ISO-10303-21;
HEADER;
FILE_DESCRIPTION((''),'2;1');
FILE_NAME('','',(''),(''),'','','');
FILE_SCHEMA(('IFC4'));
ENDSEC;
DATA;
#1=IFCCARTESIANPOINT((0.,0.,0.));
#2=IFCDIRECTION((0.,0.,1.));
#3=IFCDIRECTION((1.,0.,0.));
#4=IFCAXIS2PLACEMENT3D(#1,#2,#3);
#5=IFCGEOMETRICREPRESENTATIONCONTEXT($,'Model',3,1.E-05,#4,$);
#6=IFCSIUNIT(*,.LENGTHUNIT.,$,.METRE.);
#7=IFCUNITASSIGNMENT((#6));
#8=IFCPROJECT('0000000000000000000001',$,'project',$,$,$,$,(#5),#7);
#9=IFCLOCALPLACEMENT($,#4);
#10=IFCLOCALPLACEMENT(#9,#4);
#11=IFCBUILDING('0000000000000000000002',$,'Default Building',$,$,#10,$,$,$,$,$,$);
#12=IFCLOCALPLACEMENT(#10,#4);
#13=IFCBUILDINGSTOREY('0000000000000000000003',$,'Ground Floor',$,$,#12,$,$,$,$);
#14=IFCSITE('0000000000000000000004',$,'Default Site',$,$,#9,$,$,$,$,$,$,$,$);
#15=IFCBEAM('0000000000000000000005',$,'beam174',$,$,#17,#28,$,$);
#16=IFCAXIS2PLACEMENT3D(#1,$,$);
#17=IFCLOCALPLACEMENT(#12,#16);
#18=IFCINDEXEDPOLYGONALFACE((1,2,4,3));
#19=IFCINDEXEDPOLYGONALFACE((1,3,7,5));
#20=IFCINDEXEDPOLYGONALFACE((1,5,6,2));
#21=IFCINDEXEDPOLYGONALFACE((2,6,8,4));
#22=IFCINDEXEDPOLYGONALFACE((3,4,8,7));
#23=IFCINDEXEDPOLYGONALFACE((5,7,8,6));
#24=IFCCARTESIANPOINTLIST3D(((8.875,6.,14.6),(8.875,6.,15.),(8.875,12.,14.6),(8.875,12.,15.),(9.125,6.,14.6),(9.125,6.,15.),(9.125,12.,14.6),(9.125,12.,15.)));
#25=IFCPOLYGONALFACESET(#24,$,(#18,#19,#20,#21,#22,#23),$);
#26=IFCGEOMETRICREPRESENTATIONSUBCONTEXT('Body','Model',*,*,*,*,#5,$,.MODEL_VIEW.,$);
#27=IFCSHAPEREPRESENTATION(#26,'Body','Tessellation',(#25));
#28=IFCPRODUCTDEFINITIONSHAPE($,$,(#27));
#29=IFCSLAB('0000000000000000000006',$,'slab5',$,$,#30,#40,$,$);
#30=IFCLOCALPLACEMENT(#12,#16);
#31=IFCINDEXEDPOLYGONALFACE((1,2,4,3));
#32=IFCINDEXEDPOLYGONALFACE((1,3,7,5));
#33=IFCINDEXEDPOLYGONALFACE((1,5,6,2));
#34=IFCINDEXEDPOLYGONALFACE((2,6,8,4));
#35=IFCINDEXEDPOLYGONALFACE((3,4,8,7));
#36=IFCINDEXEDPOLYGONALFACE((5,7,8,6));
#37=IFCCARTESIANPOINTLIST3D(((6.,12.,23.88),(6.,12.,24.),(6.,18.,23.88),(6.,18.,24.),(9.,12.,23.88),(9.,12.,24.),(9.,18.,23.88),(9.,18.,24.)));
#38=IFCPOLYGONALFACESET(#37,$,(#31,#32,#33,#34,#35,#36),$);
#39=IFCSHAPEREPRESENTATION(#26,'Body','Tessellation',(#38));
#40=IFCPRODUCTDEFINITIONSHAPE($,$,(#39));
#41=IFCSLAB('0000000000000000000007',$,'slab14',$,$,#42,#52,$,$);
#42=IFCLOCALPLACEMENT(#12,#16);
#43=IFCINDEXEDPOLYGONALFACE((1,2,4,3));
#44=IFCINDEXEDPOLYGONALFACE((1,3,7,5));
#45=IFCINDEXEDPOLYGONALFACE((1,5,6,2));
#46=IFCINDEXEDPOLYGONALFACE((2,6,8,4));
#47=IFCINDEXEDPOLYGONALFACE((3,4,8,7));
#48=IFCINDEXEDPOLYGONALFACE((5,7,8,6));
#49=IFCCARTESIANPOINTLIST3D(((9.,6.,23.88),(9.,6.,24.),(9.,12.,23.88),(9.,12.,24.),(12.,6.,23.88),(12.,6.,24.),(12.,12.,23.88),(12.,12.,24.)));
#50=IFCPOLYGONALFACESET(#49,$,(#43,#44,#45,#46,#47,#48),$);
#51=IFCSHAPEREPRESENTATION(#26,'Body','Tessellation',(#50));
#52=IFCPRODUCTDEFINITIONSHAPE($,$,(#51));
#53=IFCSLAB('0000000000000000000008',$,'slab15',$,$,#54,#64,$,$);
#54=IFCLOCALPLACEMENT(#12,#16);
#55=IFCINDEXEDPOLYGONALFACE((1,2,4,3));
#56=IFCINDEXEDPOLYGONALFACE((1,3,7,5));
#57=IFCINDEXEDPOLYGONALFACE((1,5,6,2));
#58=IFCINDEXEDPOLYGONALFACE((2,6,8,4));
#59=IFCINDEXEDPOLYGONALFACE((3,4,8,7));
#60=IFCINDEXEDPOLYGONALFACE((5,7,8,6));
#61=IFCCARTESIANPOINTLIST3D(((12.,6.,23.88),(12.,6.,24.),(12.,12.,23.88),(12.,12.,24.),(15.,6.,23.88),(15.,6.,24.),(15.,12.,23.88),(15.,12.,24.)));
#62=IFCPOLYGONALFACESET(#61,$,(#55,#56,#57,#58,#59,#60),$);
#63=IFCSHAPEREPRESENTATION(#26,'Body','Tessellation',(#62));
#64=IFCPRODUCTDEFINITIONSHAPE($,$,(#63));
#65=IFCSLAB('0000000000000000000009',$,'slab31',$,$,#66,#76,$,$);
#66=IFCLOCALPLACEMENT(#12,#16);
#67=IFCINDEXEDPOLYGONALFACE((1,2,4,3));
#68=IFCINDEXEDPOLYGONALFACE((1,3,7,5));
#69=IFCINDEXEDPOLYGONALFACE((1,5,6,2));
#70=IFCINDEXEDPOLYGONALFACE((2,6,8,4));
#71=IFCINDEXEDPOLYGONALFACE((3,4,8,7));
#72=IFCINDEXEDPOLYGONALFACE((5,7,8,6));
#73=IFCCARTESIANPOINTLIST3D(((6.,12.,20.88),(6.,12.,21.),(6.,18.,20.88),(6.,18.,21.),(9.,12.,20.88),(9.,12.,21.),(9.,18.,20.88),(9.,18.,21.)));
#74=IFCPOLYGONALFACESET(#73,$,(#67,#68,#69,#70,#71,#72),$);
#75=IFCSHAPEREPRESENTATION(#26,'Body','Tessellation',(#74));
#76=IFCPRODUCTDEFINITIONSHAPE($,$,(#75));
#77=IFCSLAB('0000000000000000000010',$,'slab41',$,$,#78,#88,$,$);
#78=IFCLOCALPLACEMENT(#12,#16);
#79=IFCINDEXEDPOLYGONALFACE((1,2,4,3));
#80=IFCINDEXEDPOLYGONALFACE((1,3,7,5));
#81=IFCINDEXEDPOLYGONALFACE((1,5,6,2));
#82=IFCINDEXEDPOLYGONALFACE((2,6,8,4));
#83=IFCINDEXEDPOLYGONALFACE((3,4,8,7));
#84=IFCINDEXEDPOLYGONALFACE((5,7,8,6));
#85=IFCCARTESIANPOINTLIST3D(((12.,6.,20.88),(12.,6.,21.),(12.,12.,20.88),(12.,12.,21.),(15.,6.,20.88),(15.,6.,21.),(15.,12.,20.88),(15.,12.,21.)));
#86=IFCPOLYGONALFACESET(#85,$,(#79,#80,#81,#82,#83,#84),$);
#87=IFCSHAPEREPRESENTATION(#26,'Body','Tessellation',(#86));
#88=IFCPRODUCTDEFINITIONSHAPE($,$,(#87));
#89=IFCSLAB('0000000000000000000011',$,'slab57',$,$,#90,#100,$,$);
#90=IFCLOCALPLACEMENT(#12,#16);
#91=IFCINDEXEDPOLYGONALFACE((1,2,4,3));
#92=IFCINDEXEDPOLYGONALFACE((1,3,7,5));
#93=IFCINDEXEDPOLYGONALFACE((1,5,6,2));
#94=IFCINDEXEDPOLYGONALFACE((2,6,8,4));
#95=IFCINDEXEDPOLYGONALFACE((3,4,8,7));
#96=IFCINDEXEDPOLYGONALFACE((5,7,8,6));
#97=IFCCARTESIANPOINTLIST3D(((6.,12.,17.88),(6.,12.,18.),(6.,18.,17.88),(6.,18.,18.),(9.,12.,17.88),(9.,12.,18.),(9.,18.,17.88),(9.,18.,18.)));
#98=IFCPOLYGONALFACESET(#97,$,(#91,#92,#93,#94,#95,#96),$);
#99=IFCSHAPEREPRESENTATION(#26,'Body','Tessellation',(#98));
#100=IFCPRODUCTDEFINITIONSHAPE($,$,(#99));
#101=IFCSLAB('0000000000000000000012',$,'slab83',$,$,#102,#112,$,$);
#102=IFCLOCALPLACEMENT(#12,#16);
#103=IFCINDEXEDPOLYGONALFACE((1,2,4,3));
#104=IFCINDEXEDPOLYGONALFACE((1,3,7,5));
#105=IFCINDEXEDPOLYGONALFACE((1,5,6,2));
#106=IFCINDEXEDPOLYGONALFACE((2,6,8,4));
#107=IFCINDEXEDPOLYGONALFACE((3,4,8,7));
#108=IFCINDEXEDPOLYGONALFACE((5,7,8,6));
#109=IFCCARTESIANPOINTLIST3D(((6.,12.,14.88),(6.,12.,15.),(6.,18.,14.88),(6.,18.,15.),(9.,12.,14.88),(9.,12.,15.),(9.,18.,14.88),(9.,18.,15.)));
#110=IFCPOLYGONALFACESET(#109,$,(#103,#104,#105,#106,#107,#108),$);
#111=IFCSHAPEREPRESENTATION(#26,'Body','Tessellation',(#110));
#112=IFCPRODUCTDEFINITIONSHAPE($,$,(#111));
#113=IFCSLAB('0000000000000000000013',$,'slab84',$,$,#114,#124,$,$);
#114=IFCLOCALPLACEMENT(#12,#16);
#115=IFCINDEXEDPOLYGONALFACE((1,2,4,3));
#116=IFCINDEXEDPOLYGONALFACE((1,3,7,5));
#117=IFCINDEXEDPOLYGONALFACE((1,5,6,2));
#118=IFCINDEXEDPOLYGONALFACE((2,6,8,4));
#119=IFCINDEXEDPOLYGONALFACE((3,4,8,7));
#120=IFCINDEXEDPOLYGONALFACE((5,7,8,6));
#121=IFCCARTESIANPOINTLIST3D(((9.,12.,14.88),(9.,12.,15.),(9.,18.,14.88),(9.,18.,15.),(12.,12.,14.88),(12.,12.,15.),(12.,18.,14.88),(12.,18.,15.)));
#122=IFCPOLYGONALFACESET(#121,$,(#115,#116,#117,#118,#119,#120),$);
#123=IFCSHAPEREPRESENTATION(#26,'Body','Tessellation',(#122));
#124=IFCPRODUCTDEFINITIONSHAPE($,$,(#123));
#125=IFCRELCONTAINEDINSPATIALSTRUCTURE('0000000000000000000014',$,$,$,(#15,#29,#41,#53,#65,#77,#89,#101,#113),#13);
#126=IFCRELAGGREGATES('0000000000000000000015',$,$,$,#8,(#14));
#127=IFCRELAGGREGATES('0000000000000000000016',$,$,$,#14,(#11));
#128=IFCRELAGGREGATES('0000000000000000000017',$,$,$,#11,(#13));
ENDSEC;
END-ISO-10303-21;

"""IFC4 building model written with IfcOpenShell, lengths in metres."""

from ifc_helpers import new_model, si_unit, frame, origin_with_axes, place, context, subcontext, project, spatial, indexed_curve, outline, extrude, element, save


model = new_model("IFC4")

# Units and contexts
model_context = context("Model", 3, precision=1e-05, world=origin_with_axes())
body_context = subcontext(model_context, "Body", "Model", "MODEL_VIEW")
ifc_project = project(units=[si_unit("LENGTHUNIT", "METRE")], contexts=[model_context])

# Site, building, storey
site_placement = place(None, origin_with_axes())
site = spatial("IfcSite", under=ifc_project, at=site_placement, Name="Default Site")
building_placement = place(site_placement, origin_with_axes())
building = spatial("IfcBuilding", under=site, at=building_placement, Name="Default Building")
storey_placement = place(building_placement, origin_with_axes())
storey = spatial("IfcBuildingStorey", under=building, at=storey_placement, Name="Ground Floor")

# Beam
beam_1_placement = place(storey_placement, frame((8.875, 12.0, 14.6), z_axis=(0.0, 0.0, 1.0), x_axis=(0.0, -1.0, 0.0)))
element("IfcBeam", 1, at=beam_1_placement, inside=storey, Name="beam174", context=body_context, shape_type="SweptSolid", body=[
    extrude(outline(indexed_curve([(0.0, 0.0), (0.0, 0.25), (6.0, 0.25), (6.0, 0.0), (0.0, 0.0)], self_intersect=False)), origin_with_axes(), (0.0, 0.0, 1.0), 0.4),
])

# Slabs
for number, where, z_axis, x_axis, name in (
    (2, (6.0, 12.0, 23.88), (0.0, 0.0, 1.0), (1.0, 0.0, 0.0), "slab5"),
    (3, (9.0, 6.0, 23.88), (0.0, 0.0, 1.0), (1.0, 0.0, 0.0), "slab14"),
    (4, (12.0, 6.0, 23.88), (0.0, 0.0, 1.0), (1.0, 0.0, 0.0), "slab15"),
    (5, (6.0, 12.0, 20.88), (0.0, 0.0, 1.0), (1.0, 0.0, 0.0), "slab31"),
    (6, (12.0, 6.0, 20.88), (0.0, 0.0, 1.0), (1.0, 0.0, 0.0), "slab41"),
    (7, (6.0, 12.0, 17.88), (0.0, 0.0, 1.0), (1.0, 0.0, 0.0), "slab57"),
    (8, (6.0, 12.0, 14.88), (0.0, 0.0, 1.0), (1.0, 0.0, 0.0), "slab83"),
    (9, (9.0, 12.0, 14.88), (0.0, 0.0, 1.0), (1.0, 0.0, 0.0), "slab84"),
):
    element("IfcSlab", number, at=place(storey_placement, frame(where, z_axis=z_axis, x_axis=x_axis)), inside=storey, Name=name, context=body_context, shape_type="SweptSolid", body=[
        extrude(outline(indexed_curve([(0.0, 0.0), (0.0, 6.0), (3.0, 6.0), (3.0, 0.0), (0.0, 0.0)], self_intersect=False)), origin_with_axes(), (0.0, 0.0, 1.0), 0.12),
    ])

save(model, "model.ifc")
